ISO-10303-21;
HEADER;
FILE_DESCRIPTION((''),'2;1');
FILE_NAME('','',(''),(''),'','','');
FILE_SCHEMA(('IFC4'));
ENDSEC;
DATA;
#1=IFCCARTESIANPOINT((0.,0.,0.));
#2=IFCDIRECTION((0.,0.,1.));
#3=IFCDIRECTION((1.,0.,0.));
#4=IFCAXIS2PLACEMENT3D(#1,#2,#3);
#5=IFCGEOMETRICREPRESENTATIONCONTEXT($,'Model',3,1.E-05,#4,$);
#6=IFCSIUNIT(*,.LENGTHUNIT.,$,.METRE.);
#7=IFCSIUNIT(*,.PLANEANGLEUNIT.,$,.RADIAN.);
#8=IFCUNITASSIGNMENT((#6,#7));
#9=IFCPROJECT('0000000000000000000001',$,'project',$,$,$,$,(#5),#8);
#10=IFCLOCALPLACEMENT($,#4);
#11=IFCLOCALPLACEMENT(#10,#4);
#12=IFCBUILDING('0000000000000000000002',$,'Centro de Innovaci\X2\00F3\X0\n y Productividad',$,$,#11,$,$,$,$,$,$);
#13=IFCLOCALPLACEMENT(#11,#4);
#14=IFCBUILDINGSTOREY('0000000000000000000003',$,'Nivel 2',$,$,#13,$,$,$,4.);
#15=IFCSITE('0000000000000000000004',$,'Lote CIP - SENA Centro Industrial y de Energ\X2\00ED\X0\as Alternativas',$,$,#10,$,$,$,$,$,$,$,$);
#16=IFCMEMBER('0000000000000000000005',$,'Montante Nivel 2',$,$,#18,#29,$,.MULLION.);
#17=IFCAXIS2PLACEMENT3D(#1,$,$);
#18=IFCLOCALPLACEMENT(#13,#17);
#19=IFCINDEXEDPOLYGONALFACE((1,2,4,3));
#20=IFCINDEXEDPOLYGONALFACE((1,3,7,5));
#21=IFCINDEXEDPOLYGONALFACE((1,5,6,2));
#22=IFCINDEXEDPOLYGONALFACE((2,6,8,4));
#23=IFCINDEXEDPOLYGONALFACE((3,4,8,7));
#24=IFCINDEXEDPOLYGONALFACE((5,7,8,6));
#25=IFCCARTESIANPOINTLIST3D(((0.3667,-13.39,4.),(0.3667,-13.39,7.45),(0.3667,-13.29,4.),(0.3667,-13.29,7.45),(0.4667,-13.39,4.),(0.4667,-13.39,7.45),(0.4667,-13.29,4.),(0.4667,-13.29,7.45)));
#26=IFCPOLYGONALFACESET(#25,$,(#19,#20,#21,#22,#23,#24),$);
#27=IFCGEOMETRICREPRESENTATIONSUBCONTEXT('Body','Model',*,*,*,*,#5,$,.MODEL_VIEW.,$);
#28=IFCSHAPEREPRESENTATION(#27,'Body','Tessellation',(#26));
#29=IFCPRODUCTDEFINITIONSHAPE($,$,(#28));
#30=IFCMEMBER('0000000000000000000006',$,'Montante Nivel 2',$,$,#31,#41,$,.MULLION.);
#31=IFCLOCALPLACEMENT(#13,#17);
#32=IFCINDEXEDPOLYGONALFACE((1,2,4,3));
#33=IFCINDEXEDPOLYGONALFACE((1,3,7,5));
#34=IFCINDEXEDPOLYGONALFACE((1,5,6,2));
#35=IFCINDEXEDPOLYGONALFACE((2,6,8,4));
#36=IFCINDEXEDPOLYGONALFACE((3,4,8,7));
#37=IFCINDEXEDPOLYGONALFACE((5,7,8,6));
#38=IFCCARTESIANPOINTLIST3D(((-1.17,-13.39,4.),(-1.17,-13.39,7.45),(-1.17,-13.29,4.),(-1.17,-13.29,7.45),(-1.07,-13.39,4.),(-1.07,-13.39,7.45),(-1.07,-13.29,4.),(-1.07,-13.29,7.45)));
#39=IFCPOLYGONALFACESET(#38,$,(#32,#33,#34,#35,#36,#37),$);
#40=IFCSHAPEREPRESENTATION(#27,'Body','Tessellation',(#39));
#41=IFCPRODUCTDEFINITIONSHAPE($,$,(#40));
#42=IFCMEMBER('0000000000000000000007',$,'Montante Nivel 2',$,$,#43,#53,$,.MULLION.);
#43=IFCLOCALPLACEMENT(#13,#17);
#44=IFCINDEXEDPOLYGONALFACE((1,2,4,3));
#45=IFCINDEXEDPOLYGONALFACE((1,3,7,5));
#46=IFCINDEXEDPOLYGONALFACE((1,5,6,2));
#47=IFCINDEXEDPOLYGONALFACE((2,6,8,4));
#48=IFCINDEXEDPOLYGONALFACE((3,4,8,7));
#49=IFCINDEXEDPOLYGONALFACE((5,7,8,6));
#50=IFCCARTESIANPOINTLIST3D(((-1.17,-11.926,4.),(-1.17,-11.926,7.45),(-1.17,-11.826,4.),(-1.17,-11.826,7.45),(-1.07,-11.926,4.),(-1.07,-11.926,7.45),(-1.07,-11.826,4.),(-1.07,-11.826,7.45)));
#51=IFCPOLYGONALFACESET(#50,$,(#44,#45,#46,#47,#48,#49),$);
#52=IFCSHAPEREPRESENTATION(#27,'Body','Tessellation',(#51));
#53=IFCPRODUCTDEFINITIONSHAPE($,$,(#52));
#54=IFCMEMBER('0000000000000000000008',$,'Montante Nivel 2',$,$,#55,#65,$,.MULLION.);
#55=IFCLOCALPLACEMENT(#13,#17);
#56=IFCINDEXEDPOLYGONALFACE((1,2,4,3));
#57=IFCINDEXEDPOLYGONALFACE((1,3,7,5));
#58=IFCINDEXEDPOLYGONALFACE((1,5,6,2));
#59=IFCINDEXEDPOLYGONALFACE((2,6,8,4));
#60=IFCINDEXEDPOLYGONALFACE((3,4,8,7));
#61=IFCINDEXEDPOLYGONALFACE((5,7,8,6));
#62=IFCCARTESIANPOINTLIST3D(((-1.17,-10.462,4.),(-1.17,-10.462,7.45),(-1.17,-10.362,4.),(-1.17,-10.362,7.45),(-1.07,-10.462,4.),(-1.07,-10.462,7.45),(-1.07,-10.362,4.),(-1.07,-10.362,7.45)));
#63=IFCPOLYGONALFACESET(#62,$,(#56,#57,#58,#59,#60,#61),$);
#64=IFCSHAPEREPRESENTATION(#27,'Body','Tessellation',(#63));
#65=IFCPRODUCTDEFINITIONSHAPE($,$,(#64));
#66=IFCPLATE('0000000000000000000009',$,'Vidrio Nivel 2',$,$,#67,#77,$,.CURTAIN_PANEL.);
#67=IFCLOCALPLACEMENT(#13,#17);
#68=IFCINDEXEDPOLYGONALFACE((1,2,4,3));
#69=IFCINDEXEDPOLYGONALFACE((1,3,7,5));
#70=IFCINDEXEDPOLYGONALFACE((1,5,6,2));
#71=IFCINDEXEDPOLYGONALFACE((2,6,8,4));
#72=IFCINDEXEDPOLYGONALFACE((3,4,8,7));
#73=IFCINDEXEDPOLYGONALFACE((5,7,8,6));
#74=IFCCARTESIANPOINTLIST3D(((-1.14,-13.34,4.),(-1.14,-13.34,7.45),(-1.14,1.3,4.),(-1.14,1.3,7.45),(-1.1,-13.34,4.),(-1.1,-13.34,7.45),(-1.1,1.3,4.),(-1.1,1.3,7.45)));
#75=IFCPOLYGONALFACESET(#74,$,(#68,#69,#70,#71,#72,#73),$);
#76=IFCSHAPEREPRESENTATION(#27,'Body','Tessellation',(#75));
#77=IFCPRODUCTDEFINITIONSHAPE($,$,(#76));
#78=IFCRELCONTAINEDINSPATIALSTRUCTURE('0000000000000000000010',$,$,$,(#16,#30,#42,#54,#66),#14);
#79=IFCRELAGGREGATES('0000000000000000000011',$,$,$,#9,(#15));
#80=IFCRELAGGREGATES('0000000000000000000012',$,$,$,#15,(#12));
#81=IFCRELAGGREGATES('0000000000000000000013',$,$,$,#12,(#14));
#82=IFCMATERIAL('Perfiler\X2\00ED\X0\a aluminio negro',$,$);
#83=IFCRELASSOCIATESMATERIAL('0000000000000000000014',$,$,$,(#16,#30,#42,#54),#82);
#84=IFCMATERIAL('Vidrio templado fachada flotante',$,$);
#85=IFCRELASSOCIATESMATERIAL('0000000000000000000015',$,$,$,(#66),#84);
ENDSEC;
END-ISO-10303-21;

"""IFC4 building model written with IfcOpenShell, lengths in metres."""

from ifc_helpers import new_model, si_unit, frame, origin_with_axes, place, context, subcontext, project, spatial, polyline, outline, extrude, material, element, save


model = new_model("IFC4")

# Units and contexts
model_context = context("Model", 3, precision=1e-05, world=origin_with_axes())
body_context = subcontext(model_context, "Body", "Model", "MODEL_VIEW")
ifc_project = project(units=[si_unit("LENGTHUNIT", "METRE"), si_unit("PLANEANGLEUNIT", "RADIAN")], contexts=[model_context])

# Site, building, storey
site_placement = place(None, origin_with_axes())
site = spatial("IfcSite", under=ifc_project, at=site_placement, Name="Lote CIP - SENA Centro Industrial y de Energías Alternativas")
building_placement = place(site_placement, origin_with_axes())
building = spatial("IfcBuilding", under=site, at=building_placement, Name="Centro de Innovación y Productividad")
storey_placement = place(building_placement, origin_with_axes())
storey = spatial("IfcBuildingStorey", under=building, at=storey_placement, Name="Nivel 2", Elevation=4.0)

# Members
ifc_material_1 = material(Name="Perfilería aluminio negro")
member_1_placement = place(storey_placement, origin_with_axes())
element("IfcMember", 1, at=member_1_placement, inside=storey, material=ifc_material_1, Name="Montante Nivel 2", PredefinedType="MULLION", context=body_context, shape_type="SweptSolid", body=[
    extrude(outline(polyline([(0.4667, -13.29), (0.4667, -13.39), (0.3667, -13.39), (0.3667, -13.29), (0.4667, -13.29)])), frame((0.0, 0.0, 4.0)), (0.0, 0.0, 1.0), 3.45),
])
for number, where, z_axis, x_axis, name in (
    (2, (0.0, 0.0, 0.0), (0.0, 0.0, 1.0), (1.0, 0.0, 0.0), "Montante Nivel 2"),
):
    element("IfcMember", number, at=place(storey_placement, frame(where, z_axis=z_axis, x_axis=x_axis)), inside=storey, material=ifc_material_1, Name=name, PredefinedType="MULLION", context=body_context, shape_type="SweptSolid", body=[
        extrude(outline(polyline([(-1.07, -13.29), (-1.07, -13.39), (-1.17, -13.39), (-1.17, -13.29), (-1.07, -13.29)])), frame((0.0, 0.0, 4.0)), (0.0, 0.0, 1.0), 3.45),
    ])
member_2_placement = place(storey_placement, origin_with_axes())
element("IfcMember", 3, at=member_2_placement, inside=storey, material=ifc_material_1, Name="Montante Nivel 2", PredefinedType="MULLION", context=body_context, shape_type="SweptSolid", body=[
    extrude(outline(polyline([(-1.07, -11.826), (-1.07, -11.926), (-1.17, -11.926), (-1.17, -11.826), (-1.07, -11.826)])), frame((0.0, 0.0, 4.0)), (0.0, 0.0, 1.0), 3.45),
])
member_3_placement = place(storey_placement, origin_with_axes())
element("IfcMember", 4, at=member_3_placement, inside=storey, material=ifc_material_1, Name="Montante Nivel 2", PredefinedType="MULLION", context=body_context, shape_type="SweptSolid", body=[
    extrude(outline(polyline([(-1.07, -10.362), (-1.07, -10.462), (-1.17, -10.462), (-1.17, -10.362), (-1.07, -10.362)])), frame((0.0, 0.0, 4.0)), (0.0, 0.0, 1.0), 3.45),
])

# Plate
ifc_material_2 = material(Name="Vidrio templado fachada flotante")
plate_placement = place(storey_placement, origin_with_axes())
element("IfcPlate", 5, at=plate_placement, inside=storey, material=ifc_material_2, Name="Vidrio Nivel 2", PredefinedType="CURTAIN_PANEL", context=body_context, shape_type="SweptSolid", body=[
    extrude(outline(polyline([(-1.1, 1.3), (-1.1, -13.34), (-1.14, -13.34), (-1.14, 1.3), (-1.1, 1.3)])), frame((0.0, 0.0, 4.0)), (0.0, 0.0, 1.0), 3.45),
])

save(model, "model.ifc")
